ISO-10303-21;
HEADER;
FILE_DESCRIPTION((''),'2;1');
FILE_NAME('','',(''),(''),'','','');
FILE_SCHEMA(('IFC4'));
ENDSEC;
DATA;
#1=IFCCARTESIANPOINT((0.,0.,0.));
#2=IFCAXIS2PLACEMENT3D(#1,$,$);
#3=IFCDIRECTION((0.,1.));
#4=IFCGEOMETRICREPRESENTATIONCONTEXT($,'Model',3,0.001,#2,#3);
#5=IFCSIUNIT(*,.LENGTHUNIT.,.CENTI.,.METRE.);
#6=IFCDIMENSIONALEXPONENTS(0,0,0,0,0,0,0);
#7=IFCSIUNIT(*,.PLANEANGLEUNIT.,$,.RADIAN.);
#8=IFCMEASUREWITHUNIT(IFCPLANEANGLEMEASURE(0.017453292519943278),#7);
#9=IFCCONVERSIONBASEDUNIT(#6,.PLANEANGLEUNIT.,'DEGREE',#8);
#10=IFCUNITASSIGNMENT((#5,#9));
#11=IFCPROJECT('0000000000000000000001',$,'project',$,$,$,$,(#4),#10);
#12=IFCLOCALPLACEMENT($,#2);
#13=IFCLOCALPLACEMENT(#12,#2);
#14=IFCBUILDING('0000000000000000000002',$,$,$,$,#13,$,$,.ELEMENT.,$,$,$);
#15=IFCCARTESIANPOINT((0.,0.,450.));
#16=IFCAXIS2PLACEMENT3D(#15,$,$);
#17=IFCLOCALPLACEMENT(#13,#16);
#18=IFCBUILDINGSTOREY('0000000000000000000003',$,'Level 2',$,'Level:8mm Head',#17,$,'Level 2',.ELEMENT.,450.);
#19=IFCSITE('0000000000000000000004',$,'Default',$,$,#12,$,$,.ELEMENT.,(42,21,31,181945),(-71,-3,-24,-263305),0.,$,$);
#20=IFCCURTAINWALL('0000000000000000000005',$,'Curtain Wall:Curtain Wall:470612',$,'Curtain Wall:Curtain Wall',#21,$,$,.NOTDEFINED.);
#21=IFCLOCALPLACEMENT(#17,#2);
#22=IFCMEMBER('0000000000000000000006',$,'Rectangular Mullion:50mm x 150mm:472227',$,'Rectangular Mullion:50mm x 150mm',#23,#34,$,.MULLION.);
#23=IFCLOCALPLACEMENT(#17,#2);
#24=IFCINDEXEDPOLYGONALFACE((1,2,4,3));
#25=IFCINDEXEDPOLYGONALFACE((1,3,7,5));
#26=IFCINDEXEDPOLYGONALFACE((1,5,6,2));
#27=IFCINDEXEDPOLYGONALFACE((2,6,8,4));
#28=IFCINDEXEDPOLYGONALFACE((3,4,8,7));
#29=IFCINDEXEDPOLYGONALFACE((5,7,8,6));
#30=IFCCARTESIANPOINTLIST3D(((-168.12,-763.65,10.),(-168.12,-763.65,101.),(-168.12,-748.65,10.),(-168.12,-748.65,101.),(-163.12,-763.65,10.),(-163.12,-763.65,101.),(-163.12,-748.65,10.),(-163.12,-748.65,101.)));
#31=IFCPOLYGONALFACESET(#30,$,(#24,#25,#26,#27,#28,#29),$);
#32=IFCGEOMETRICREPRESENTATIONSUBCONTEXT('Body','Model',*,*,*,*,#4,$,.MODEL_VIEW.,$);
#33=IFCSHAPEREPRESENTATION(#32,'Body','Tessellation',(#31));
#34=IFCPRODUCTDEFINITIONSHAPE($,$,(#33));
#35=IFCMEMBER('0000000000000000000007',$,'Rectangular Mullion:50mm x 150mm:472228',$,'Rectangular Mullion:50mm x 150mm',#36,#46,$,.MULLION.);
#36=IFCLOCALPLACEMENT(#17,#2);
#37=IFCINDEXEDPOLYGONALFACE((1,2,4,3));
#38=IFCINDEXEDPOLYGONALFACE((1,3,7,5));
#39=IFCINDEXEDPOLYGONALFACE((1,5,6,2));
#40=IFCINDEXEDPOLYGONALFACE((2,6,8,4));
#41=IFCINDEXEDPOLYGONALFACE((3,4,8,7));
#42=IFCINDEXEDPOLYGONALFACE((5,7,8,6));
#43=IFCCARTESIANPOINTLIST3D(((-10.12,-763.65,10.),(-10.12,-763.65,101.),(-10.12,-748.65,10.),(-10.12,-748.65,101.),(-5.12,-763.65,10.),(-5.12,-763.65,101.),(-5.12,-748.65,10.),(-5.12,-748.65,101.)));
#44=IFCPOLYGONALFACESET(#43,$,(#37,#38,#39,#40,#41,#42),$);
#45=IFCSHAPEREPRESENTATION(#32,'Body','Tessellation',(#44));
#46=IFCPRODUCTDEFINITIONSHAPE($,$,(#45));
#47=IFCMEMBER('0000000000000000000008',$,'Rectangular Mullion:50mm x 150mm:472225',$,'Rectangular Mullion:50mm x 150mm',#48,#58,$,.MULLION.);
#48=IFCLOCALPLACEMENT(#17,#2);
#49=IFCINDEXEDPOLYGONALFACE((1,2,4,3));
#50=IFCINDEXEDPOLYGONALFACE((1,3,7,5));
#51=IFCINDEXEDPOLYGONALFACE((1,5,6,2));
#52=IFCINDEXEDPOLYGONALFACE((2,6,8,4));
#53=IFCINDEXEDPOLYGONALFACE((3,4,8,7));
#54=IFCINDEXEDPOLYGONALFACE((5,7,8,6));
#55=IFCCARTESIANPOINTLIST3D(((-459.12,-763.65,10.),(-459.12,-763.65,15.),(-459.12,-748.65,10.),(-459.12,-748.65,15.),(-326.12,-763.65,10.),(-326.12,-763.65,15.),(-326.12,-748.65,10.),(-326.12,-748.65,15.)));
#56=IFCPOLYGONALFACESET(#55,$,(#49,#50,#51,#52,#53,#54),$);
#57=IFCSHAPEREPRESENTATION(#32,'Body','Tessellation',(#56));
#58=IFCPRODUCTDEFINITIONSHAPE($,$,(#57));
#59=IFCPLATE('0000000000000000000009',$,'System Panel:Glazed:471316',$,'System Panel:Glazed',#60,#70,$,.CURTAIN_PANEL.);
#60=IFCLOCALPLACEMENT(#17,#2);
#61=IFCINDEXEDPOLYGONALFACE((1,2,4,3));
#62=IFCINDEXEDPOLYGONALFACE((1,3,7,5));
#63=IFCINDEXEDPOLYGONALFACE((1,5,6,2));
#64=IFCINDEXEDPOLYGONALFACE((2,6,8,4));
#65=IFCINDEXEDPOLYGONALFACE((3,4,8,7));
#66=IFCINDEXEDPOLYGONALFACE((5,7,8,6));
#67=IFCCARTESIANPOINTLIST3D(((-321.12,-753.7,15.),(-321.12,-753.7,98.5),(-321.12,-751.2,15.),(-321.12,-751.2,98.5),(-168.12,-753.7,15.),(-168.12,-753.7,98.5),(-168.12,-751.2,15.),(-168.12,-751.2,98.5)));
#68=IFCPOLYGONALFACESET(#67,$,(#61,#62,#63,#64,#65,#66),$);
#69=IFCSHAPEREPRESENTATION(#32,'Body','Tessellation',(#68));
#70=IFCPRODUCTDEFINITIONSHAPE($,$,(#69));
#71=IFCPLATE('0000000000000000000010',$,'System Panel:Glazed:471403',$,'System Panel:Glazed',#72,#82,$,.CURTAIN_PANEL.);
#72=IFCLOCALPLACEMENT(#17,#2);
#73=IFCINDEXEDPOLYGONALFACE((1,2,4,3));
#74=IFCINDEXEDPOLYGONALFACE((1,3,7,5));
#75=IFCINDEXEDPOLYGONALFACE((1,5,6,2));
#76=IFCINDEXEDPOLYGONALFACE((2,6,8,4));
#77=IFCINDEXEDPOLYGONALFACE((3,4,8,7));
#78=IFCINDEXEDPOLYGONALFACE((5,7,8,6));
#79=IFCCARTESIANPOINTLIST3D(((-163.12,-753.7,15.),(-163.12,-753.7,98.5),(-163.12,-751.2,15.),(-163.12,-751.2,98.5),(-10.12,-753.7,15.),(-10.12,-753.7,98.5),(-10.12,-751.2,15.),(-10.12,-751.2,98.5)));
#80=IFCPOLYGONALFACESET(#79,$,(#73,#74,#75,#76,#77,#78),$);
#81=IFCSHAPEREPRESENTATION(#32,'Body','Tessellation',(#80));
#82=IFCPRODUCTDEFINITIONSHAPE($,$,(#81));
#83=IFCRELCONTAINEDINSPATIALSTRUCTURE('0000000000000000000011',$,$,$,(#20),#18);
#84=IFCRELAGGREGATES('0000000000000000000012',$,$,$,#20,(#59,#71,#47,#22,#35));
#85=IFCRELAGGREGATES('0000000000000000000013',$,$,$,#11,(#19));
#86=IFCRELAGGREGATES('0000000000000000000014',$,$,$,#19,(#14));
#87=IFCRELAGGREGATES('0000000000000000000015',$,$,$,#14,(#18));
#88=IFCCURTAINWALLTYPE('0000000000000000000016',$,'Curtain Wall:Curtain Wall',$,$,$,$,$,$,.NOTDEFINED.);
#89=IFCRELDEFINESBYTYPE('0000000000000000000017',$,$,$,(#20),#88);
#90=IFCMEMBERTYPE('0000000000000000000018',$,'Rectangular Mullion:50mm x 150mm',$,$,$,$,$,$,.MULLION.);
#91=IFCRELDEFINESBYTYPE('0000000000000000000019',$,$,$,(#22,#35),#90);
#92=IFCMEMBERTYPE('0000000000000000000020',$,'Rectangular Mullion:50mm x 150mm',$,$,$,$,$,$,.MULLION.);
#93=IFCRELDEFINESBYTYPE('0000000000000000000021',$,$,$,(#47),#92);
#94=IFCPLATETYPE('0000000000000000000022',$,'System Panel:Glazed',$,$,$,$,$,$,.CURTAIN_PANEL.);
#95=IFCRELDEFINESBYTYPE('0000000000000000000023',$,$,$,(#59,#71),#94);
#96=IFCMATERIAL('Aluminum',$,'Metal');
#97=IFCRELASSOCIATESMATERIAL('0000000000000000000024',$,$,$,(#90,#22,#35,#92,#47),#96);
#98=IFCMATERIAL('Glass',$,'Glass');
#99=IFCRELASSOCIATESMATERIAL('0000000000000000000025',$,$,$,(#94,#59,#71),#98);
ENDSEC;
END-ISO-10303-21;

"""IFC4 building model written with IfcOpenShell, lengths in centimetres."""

from ifc_helpers import new_model, entity, si_unit, converted_unit, direction, frame, origin, place, context, subcontext, project, spatial, indexed_curve, outline, extrude, source, transform, mapped, material, type_object, type_shapes, element, aggregate, save


model = new_model("IFC4")

# Units and contexts
model_context = context("Model", 3, precision=0.001, world=origin(), true_north=direction((0.0, 1.0)))
body_context = subcontext(model_context, "Body", "Model", "MODEL_VIEW")
ifc_project = project(units=[si_unit("LENGTHUNIT", "METRE", prefix="CENTI"), converted_unit("PLANEANGLEUNIT", "DEGREE", entity("IfcPlaneAngleMeasure", 0.017453292519943278), si_unit("PLANEANGLEUNIT", "RADIAN"), dimensions=[0, 0, 0, 0, 0, 0, 0])], contexts=[model_context])

# Site, building, storey
site_placement = place(None, origin())
site = spatial("IfcSite", under=ifc_project, at=site_placement, Name="Default", CompositionType="ELEMENT", RefLatitude=(42, 21, 31, 181945), RefLongitude=(-71, -3, -24, -263305), RefElevation=0.0)
building_placement = place(site_placement, origin())
building = spatial("IfcBuilding", under=site, at=building_placement, CompositionType="ELEMENT")
storey_placement = place(building_placement, frame((0.0, 0.0, 450.0)))
storey = spatial("IfcBuildingStorey", under=building, at=storey_placement, Name="Level 2", ObjectType="Level:8mm Head", LongName="Level 2", CompositionType="ELEMENT", Elevation=450.0)

# Curtain wall
curtain_wall_type = type_object("IfcCurtainWallType", Name="Curtain Wall:Curtain Wall", PredefinedType="NOTDEFINED")
curtain_wall_placement = place(storey_placement, frame((0.0, 0.0, -450.0)))
curtain_wall = element("IfcCurtainWall", 1, at=curtain_wall_placement, inside=storey, type_object=curtain_wall_type, Name="Curtain Wall:Curtain Wall:470612", ObjectType="Curtain Wall:Curtain Wall", PredefinedType="NOTDEFINED")
ifc_material_1 = material(Name="Aluminum", Category="Metal")

# Members
member_type_1 = type_object("IfcMemberType", Name="Rectangular Mullion:50mm x 150mm", PredefinedType="MULLION", material=ifc_material_1)
shared_shape_1 = source(origin(), body_context, "Body", "SweptSolid", [
    extrude(outline(indexed_curve([(-2.5, -7.5), (2.5, -7.5), (2.5, 7.5), (-2.5, 7.5), (-2.5, -7.5)], self_intersect=False)), frame((0.0, 0.0, -91.0), z_axis=(0.0, 0.0, 1.0), x_axis=(-1.0, 0.0, 0.0)), (0.0, 0.0, 1.0), 91.0),
])
type_shapes(member_type_1, [shared_shape_1])
member_1_placement = place(curtain_wall_placement, frame((-165.62, -756.15, 460.0), z_axis=(0.0, 0.0, -1.0), x_axis=(1.0, 0.0, 0.0)))
member_1 = element("IfcMember", 2, at=member_1_placement, type_object=member_type_1, material=ifc_material_1, Name="Rectangular Mullion:50mm x 150mm:472227", ObjectType="Rectangular Mullion:50mm x 150mm", PredefinedType="MULLION", context=body_context, shape_type="MappedRepresentation", body=[
    mapped(shared_shape_1, transform((0.0, 0.0, 0.0), scale=1.0)),
])
member_2_placement = place(curtain_wall_placement, frame((-7.62, -756.15, 460.0), z_axis=(0.0, 0.0, -1.0), x_axis=(1.0, 0.0, 0.0)))
member_2 = element("IfcMember", 3, at=member_2_placement, type_object=member_type_1, material=ifc_material_1, Name="Rectangular Mullion:50mm x 150mm:472228", ObjectType="Rectangular Mullion:50mm x 150mm", PredefinedType="MULLION", context=body_context, shape_type="MappedRepresentation", body=[
    mapped(shared_shape_1, transform((0.0, 0.0, 0.0), scale=1.0)),
])
member_type_2 = type_object("IfcMemberType", Name="Rectangular Mullion:50mm x 150mm", PredefinedType="MULLION", material=ifc_material_1)
shared_shape_2 = source(origin(), body_context, "Body", "SweptSolid", [
    extrude(outline(indexed_curve([(-2.5, -7.5), (2.5, -7.5), (2.5, 7.5), (-2.5, 7.5), (-2.5, -7.5)], self_intersect=False)), frame((-2.5, 0.0, -133.0), z_axis=(0.0, 0.0, 1.0), x_axis=(-1.0, 0.0, 0.0)), (0.0, 0.0, 1.0), 133.0),
])
type_shapes(member_type_2, [shared_shape_2])
member_3_placement = place(curtain_wall_placement, frame((-459.12, -756.15, 460.0), z_axis=(-1.0, 0.0, 0.0), x_axis=(0.0, 0.0, -1.0)))
member_3 = element("IfcMember", 4, at=member_3_placement, type_object=member_type_2, material=ifc_material_1, Name="Rectangular Mullion:50mm x 150mm:472225", ObjectType="Rectangular Mullion:50mm x 150mm", PredefinedType="MULLION", context=body_context, shape_type="MappedRepresentation", body=[
    mapped(shared_shape_2, transform((0.0, 0.0, 0.0), scale=1.0)),
])

# Plates
ifc_material_2 = material(Name="Glass", Category="Glass")
plate_type = type_object("IfcPlateType", Name="System Panel:Glazed", PredefinedType="CURTAIN_PANEL", material=ifc_material_2)
shared_shape_3 = source(origin(), body_context, "Body", "SweptSolid", [
    extrude(outline(indexed_curve([(-1.25, -76.5), (1.25, -76.5), (1.25, 76.5), (-1.25, 76.5), (-1.25, -76.5)], self_intersect=False)), frame((0.0, 3.7, 0.0), z_axis=(0.0, 0.0, 1.0), x_axis=(0.0, 1.0, 0.0)), (0.0, 0.0, 1.0), 83.5),
])
type_shapes(plate_type, [shared_shape_3])
plate_1_placement = place(curtain_wall_placement, frame((-244.62, -756.15, 465.0)))
plate_1 = element("IfcPlate", 5, at=plate_1_placement, type_object=plate_type, material=ifc_material_2, Name="System Panel:Glazed:471316", ObjectType="System Panel:Glazed", PredefinedType="CURTAIN_PANEL", context=body_context, shape_type="MappedRepresentation", body=[
    mapped(shared_shape_3, transform((0.0, 0.0, 0.0), scale=1.0)),
])
plate_2_placement = place(curtain_wall_placement, frame((-86.62, -756.15, 465.0)))
plate_2 = element("IfcPlate", 6, at=plate_2_placement, type_object=plate_type, material=ifc_material_2, Name="System Panel:Glazed:471403", ObjectType="System Panel:Glazed", PredefinedType="CURTAIN_PANEL", context=body_context, shape_type="MappedRepresentation", body=[
    mapped(shared_shape_3, transform((0.0, 0.0, 0.0), scale=1.0)),
])
aggregate(curtain_wall, [plate_1, plate_2, member_3, member_1, member_2])

save(model, "model.ifc")
